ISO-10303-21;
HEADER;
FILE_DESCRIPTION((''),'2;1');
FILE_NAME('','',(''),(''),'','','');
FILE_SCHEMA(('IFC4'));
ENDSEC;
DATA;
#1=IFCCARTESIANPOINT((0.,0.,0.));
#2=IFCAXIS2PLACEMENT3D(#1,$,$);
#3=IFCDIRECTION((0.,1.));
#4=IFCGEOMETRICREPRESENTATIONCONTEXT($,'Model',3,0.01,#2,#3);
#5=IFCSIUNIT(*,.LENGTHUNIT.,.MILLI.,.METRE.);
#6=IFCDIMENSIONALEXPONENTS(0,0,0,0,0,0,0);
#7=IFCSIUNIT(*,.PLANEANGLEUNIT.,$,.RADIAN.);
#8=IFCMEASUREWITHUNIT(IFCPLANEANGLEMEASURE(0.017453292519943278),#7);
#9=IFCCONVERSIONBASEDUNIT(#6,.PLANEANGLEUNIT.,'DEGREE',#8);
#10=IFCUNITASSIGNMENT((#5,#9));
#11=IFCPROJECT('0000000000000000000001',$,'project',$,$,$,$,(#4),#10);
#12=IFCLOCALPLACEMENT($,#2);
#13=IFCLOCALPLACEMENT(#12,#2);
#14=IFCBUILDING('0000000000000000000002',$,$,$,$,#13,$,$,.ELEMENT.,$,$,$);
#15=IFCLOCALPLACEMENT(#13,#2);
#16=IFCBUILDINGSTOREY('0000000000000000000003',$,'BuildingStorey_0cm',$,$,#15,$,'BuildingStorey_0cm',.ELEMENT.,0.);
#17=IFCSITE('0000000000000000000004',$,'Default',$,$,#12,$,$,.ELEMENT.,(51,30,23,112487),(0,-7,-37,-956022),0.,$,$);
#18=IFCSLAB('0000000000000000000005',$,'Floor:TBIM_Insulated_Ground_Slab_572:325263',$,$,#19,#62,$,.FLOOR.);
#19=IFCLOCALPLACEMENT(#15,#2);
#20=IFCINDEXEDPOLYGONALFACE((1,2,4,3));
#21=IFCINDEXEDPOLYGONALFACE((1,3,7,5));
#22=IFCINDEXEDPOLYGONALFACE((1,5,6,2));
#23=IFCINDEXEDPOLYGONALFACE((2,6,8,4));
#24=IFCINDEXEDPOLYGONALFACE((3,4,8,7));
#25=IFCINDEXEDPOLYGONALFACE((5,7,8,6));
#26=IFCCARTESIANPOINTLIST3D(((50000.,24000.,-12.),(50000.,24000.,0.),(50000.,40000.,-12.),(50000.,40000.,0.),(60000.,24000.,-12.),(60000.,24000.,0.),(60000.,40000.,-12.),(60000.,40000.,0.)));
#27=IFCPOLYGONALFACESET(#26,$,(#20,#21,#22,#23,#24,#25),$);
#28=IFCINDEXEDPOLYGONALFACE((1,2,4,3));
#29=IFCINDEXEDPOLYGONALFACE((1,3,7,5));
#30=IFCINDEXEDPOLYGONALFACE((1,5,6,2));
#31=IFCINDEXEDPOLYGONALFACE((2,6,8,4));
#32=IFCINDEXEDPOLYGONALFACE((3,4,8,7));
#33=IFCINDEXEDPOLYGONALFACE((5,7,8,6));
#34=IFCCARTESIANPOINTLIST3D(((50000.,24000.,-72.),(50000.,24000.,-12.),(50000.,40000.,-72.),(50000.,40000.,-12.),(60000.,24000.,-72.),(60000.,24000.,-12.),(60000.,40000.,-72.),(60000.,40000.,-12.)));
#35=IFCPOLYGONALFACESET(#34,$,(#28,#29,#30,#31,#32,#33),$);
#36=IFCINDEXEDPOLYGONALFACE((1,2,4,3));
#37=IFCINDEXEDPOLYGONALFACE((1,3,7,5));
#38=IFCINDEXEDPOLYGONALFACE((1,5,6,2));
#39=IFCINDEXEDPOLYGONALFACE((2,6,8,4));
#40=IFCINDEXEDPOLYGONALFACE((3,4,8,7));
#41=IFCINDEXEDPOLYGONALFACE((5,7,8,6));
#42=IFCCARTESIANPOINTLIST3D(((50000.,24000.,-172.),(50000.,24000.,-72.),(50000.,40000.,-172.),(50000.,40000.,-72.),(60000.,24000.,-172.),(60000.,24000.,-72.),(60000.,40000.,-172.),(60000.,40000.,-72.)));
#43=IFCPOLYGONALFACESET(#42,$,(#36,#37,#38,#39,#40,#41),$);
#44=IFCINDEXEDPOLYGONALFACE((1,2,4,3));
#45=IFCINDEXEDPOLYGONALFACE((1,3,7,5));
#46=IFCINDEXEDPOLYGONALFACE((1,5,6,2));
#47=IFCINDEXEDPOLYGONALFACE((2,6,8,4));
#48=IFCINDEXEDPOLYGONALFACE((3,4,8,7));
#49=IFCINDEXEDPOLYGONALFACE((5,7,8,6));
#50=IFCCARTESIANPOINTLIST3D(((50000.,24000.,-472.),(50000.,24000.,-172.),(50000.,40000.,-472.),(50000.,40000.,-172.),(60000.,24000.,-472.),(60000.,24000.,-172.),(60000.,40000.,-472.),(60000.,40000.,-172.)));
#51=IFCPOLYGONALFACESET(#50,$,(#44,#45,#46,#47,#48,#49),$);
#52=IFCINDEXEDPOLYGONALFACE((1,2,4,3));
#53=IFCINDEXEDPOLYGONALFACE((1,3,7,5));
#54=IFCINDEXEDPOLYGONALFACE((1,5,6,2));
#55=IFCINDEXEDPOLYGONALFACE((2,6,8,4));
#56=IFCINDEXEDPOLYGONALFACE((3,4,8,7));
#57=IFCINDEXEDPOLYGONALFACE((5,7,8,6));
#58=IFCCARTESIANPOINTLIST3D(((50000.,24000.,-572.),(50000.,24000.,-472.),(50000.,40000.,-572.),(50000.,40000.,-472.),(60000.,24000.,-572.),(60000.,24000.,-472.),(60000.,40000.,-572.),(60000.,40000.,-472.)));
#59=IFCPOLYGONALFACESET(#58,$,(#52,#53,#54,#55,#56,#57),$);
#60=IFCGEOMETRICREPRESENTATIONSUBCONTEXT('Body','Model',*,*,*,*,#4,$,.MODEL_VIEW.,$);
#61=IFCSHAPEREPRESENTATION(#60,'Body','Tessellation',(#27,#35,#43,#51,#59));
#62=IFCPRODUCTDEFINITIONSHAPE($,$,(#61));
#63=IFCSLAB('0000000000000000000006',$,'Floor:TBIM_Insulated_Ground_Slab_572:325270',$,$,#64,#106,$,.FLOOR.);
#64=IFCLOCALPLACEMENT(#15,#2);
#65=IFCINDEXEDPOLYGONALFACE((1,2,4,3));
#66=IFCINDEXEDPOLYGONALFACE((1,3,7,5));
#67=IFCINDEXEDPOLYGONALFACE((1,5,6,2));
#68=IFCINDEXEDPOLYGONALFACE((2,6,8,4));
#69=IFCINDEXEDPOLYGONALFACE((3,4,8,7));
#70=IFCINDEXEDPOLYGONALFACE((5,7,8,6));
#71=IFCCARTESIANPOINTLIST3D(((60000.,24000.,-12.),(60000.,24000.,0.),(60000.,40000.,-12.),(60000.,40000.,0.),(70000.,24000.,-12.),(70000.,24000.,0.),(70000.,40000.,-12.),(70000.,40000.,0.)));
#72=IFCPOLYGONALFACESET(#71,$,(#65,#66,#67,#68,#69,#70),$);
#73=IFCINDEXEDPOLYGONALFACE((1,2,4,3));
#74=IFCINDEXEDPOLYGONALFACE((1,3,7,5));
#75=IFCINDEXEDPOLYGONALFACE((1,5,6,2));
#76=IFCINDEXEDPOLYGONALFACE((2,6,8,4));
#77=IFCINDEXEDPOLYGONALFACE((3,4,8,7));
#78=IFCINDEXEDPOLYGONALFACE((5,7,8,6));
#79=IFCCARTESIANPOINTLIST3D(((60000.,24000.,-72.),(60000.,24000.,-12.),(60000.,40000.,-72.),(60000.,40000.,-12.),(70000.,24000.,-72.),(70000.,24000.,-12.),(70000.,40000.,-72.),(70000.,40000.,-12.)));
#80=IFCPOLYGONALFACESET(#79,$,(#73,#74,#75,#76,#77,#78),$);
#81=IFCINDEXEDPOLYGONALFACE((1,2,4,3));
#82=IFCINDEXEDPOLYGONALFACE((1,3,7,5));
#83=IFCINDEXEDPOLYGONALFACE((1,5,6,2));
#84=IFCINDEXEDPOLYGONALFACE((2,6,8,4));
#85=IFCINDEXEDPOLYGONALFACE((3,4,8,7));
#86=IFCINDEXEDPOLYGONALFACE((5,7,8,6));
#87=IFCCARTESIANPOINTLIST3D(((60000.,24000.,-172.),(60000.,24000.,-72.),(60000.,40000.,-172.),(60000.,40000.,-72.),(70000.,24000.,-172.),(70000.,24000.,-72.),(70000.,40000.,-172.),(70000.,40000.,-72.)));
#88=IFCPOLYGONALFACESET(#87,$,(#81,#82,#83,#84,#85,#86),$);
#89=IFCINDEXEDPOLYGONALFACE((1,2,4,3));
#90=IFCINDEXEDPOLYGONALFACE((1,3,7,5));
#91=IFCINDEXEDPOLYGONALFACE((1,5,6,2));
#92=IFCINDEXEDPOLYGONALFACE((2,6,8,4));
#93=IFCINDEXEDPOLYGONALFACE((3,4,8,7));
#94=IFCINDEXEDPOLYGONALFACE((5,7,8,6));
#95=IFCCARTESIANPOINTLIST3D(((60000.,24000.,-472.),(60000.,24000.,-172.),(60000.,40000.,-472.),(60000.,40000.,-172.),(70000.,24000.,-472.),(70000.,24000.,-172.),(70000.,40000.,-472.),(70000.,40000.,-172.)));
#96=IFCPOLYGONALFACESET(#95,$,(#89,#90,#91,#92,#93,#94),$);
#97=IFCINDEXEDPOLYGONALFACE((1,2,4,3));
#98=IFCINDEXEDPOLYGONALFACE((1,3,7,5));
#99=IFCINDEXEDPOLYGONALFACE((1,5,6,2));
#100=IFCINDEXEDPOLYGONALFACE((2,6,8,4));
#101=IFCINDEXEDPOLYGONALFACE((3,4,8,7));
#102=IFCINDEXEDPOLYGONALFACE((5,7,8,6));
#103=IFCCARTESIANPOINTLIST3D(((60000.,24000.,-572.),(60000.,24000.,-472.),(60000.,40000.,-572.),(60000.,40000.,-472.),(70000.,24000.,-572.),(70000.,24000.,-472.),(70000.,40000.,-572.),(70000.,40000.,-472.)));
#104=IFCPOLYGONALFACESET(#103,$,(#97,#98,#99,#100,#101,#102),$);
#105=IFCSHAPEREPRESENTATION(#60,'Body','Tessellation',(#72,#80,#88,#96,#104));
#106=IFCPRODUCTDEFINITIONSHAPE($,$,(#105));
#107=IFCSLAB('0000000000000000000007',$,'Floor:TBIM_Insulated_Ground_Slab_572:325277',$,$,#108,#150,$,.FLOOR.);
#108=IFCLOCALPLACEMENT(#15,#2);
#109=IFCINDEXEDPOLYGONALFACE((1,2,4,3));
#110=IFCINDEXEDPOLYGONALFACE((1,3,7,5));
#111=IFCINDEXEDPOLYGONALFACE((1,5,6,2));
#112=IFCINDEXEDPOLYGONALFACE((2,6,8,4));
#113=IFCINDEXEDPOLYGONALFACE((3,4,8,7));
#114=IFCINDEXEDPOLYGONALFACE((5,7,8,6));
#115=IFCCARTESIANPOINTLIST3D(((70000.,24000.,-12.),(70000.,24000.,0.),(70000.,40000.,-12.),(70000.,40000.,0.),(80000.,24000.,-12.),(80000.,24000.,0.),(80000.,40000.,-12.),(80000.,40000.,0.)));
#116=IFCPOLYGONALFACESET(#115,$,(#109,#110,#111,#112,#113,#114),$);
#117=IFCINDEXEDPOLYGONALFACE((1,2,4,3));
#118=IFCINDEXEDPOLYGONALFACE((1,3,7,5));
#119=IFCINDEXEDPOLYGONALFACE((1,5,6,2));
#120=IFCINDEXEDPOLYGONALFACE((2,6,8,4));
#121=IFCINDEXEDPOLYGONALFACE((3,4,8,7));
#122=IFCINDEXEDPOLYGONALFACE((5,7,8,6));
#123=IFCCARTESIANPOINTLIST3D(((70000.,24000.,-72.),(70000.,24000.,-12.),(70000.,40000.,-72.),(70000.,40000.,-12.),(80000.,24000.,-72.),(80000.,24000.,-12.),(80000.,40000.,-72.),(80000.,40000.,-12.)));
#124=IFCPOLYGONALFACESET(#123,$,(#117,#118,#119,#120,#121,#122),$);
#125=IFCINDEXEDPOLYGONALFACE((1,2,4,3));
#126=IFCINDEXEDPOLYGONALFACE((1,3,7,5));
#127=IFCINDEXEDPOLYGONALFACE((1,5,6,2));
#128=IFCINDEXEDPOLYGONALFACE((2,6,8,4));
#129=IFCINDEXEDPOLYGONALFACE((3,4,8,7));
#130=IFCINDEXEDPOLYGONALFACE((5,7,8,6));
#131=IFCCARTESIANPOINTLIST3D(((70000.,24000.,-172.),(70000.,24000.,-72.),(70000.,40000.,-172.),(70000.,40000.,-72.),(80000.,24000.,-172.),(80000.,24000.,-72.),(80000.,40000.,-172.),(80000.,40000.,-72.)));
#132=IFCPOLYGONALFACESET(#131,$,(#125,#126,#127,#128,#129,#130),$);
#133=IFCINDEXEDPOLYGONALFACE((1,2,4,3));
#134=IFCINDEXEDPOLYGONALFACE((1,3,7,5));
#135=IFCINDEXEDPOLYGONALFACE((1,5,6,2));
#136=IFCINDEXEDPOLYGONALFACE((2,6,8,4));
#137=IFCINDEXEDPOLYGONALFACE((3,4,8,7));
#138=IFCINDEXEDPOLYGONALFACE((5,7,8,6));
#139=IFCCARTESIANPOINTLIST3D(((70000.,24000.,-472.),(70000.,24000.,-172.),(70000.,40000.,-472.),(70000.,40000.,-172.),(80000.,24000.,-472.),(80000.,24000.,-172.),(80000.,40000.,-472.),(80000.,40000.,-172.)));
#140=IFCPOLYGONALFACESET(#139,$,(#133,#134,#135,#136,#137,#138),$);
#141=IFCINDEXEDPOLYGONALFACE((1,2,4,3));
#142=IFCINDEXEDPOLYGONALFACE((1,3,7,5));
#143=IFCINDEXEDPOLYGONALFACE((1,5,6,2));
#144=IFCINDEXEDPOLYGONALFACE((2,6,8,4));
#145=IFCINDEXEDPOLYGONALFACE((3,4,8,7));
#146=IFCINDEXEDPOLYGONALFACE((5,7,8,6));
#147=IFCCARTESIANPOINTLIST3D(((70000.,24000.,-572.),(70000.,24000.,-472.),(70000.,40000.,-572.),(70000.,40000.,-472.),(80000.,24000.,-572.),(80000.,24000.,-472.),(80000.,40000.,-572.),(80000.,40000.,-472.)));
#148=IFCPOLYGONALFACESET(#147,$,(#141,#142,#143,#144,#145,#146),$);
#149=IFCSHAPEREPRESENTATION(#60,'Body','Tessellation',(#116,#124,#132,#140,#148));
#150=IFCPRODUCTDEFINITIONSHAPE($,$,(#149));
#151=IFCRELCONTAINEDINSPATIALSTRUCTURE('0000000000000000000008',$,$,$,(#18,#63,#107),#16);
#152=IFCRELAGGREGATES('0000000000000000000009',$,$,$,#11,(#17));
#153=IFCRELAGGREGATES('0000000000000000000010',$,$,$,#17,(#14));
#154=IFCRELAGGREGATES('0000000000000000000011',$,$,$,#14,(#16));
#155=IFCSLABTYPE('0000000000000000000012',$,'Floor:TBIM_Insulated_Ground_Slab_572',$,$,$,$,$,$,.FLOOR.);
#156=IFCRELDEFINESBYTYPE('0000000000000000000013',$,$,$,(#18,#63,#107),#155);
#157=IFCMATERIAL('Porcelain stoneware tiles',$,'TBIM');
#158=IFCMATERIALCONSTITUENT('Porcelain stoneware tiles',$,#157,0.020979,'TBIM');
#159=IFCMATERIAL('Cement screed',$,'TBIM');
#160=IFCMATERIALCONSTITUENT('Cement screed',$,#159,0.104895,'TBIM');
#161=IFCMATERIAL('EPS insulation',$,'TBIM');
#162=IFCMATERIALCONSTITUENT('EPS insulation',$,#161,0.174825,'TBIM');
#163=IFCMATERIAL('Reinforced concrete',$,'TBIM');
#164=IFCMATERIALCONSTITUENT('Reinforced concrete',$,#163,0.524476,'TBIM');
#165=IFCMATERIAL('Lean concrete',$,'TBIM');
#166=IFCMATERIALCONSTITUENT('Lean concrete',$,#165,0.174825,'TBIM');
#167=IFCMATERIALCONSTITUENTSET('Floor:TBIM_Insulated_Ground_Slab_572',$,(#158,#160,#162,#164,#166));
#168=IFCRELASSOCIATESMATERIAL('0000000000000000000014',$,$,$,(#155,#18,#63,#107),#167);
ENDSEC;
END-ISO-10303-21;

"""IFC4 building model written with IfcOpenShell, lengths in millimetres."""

from ifc_helpers import new_model, entity, si_unit, converted_unit, direction, frame, origin, place, context, subcontext, project, spatial, indexed_curve, outline, extrude, material, constituent, constituent_set, type_object, element, save


model = new_model("IFC4")

# Units and contexts
model_context = context("Model", 3, precision=0.01, world=origin(), true_north=direction((0.0, 1.0)))
body_context = subcontext(model_context, "Body", "Model", "MODEL_VIEW")
ifc_project = project(units=[si_unit("LENGTHUNIT", "METRE", prefix="MILLI"), converted_unit("PLANEANGLEUNIT", "DEGREE", entity("IfcPlaneAngleMeasure", 0.017453292519943278), si_unit("PLANEANGLEUNIT", "RADIAN"), dimensions=[0, 0, 0, 0, 0, 0, 0])], contexts=[model_context])

# Site, building, storey
site_placement = place(None, origin())
site = spatial("IfcSite", under=ifc_project, at=site_placement, Name="Default", CompositionType="ELEMENT", RefLatitude=(51, 30, 23, 112487), RefLongitude=(0, -7, -37, -956022), RefElevation=0.0)
building_placement = place(site_placement, origin())
building = spatial("IfcBuilding", under=site, at=building_placement, CompositionType="ELEMENT")
storey_placement = place(building_placement, origin())
storey = spatial("IfcBuildingStorey", under=building, at=storey_placement, Name="BuildingStorey_0cm", LongName="BuildingStorey_0cm", CompositionType="ELEMENT", Elevation=0.0)

# Slabs
ifc_material_1 = material(Name="Porcelain stoneware tiles", Category="TBIM")
ifc_constituent_1 = constituent(ifc_material_1, Name="Porcelain stoneware tiles", Category="TBIM", fraction=0.020979)
ifc_material_2 = material(Name="Cement screed", Category="TBIM")
ifc_constituent_2 = constituent(ifc_material_2, Name="Cement screed", Category="TBIM", fraction=0.104895)
ifc_material_3 = material(Name="EPS insulation", Category="TBIM")
ifc_constituent_3 = constituent(ifc_material_3, Name="EPS insulation", Category="TBIM", fraction=0.174825)
ifc_material_4 = material(Name="Reinforced concrete", Category="TBIM")
ifc_constituent_4 = constituent(ifc_material_4, Name="Reinforced concrete", Category="TBIM", fraction=0.524476)
ifc_material_5 = material(Name="Lean concrete", Category="TBIM")
ifc_constituent_5 = constituent(ifc_material_5, Name="Lean concrete", Category="TBIM", fraction=0.174825)
ifc_constituent_set_1 = constituent_set(constituents=[ifc_constituent_1, ifc_constituent_2, ifc_constituent_3, ifc_constituent_4, ifc_constituent_5], Name="Floor:TBIM_Insulated_Ground_Slab_572")
slab_type = type_object("IfcSlabType", Name="Floor:TBIM_Insulated_Ground_Slab_572", PredefinedType="FLOOR", material=ifc_constituent_set_1)
slab_1_placement = place(storey_placement, origin())
element("IfcSlab", 1, at=slab_1_placement, inside=storey, type_object=slab_type, material=ifc_constituent_set_1, Name="Floor:TBIM_Insulated_Ground_Slab_572:325263", PredefinedType="FLOOR", context=body_context, shape_type="SweptSolid", body=[
    extrude(outline(indexed_curve([(-5000.0, -8000.0), (5000.0, -8000.0), (5000.0, 8000.0), (-5000.0, 8000.0), (-5000.0, -8000.0)], self_intersect=False)), frame((55000.0, 32000.0, -12.0), z_axis=(0.0, 0.0, 1.0), x_axis=(-1.0, 0.0, 0.0)), (0.0, 0.0, 1.0), 12.0),
    extrude(outline(indexed_curve([(-5000.0, -8000.0), (5000.0, -8000.0), (5000.0, 8000.0), (-5000.0, 8000.0), (-5000.0, -8000.0)], self_intersect=False)), frame((55000.0, 32000.0, -72.0), z_axis=(0.0, 0.0, 1.0), x_axis=(-1.0, 0.0, 0.0)), (0.0, 0.0, 1.0), 60.0),
    extrude(outline(indexed_curve([(-5000.0, -8000.0), (5000.0, -8000.0), (5000.0, 8000.0), (-5000.0, 8000.0), (-5000.0, -8000.0)], self_intersect=False)), frame((55000.0, 32000.0, -172.0), z_axis=(0.0, 0.0, 1.0), x_axis=(-1.0, 0.0, 0.0)), (0.0, 0.0, 1.0), 100.0),
    extrude(outline(indexed_curve([(-5000.0, -8000.0), (5000.0, -8000.0), (5000.0, 8000.0), (-5000.0, 8000.0), (-5000.0, -8000.0)], self_intersect=False)), frame((55000.0, 32000.0, -472.0), z_axis=(0.0, 0.0, 1.0), x_axis=(-1.0, 0.0, 0.0)), (0.0, 0.0, 1.0), 300.0),
    extrude(outline(indexed_curve([(-5000.0, -8000.0), (5000.0, -8000.0), (5000.0, 8000.0), (-5000.0, 8000.0), (-5000.0, -8000.0)], self_intersect=False)), frame((55000.0, 32000.0, -572.0), z_axis=(0.0, 0.0, 1.0), x_axis=(-1.0, 0.0, 0.0)), (0.0, 0.0, 1.0), 100.0),
])
slab_2_placement = place(storey_placement, origin())
element("IfcSlab", 2, at=slab_2_placement, inside=storey, type_object=slab_type, material=ifc_constituent_set_1, Name="Floor:TBIM_Insulated_Ground_Slab_572:325270", PredefinedType="FLOOR", context=body_context, shape_type="SweptSolid", body=[
    extrude(outline(indexed_curve([(-5000.0, -8000.0), (5000.0, -8000.0), (5000.0, 8000.0), (-5000.0, 8000.0), (-5000.0, -8000.0)], self_intersect=False)), frame((65000.0, 32000.0, -12.0), z_axis=(0.0, 0.0, 1.0), x_axis=(-1.0, 0.0, 0.0)), (0.0, 0.0, 1.0), 12.0),
    extrude(outline(indexed_curve([(-5000.0, -8000.0), (5000.0, -8000.0), (5000.0, 8000.0), (-5000.0, 8000.0), (-5000.0, -8000.0)], self_intersect=False)), frame((65000.0, 32000.0, -72.0), z_axis=(0.0, 0.0, 1.0), x_axis=(-1.0, 0.0, 0.0)), (0.0, 0.0, 1.0), 60.0),
    extrude(outline(indexed_curve([(-5000.0, -8000.0), (5000.0, -8000.0), (5000.0, 8000.0), (-5000.0, 8000.0), (-5000.0, -8000.0)], self_intersect=False)), frame((65000.0, 32000.0, -172.0), z_axis=(0.0, 0.0, 1.0), x_axis=(-1.0, 0.0, 0.0)), (0.0, 0.0, 1.0), 100.0),
    extrude(outline(indexed_curve([(-5000.0, -8000.0), (5000.0, -8000.0), (5000.0, 8000.0), (-5000.0, 8000.0), (-5000.0, -8000.0)], self_intersect=False)), frame((65000.0, 32000.0, -472.0), z_axis=(0.0, 0.0, 1.0), x_axis=(-1.0, 0.0, 0.0)), (0.0, 0.0, 1.0), 300.0),
    extrude(outline(indexed_curve([(-5000.0, -8000.0), (5000.0, -8000.0), (5000.0, 8000.0), (-5000.0, 8000.0), (-5000.0, -8000.0)], self_intersect=False)), frame((65000.0, 32000.0, -572.0), z_axis=(0.0, 0.0, 1.0), x_axis=(-1.0, 0.0, 0.0)), (0.0, 0.0, 1.0), 100.0),
])
slab_3_placement = place(storey_placement, origin())
element("IfcSlab", 3, at=slab_3_placement, inside=storey, type_object=slab_type, material=ifc_constituent_set_1, Name="Floor:TBIM_Insulated_Ground_Slab_572:325277", PredefinedType="FLOOR", context=body_context, shape_type="SweptSolid", body=[
    extrude(outline(indexed_curve([(-5000.0, -8000.0), (5000.0, -8000.0), (5000.0, 8000.0), (-5000.0, 8000.0), (-5000.0, -8000.0)], self_intersect=False)), frame((75000.0, 32000.0, -12.0), z_axis=(0.0, 0.0, 1.0), x_axis=(-1.0, 0.0, 0.0)), (0.0, 0.0, 1.0), 12.0),
    extrude(outline(indexed_curve([(-5000.0, -8000.0), (5000.0, -8000.0), (5000.0, 8000.0), (-5000.0, 8000.0), (-5000.0, -8000.0)], self_intersect=False)), frame((75000.0, 32000.0, -72.0), z_axis=(0.0, 0.0, 1.0), x_axis=(-1.0, 0.0, 0.0)), (0.0, 0.0, 1.0), 60.0),
    extrude(outline(indexed_curve([(-5000.0, -8000.0), (5000.0, -8000.0), (5000.0, 8000.0), (-5000.0, 8000.0), (-5000.0, -8000.0)], self_intersect=False)), frame((75000.0, 32000.0, -172.0), z_axis=(0.0, 0.0, 1.0), x_axis=(-1.0, 0.0, 0.0)), (0.0, 0.0, 1.0), 100.0),
    extrude(outline(indexed_curve([(-5000.0, -8000.0), (5000.0, -8000.0), (5000.0, 8000.0), (-5000.0, 8000.0), (-5000.0, -8000.0)], self_intersect=False)), frame((75000.0, 32000.0, -472.0), z_axis=(0.0, 0.0, 1.0), x_axis=(-1.0, 0.0, 0.0)), (0.0, 0.0, 1.0), 300.0),
    extrude(outline(indexed_curve([(-5000.0, -8000.0), (5000.0, -8000.0), (5000.0, 8000.0), (-5000.0, 8000.0), (-5000.0, -8000.0)], self_intersect=False)), frame((75000.0, 32000.0, -572.0), z_axis=(0.0, 0.0, 1.0), x_axis=(-1.0, 0.0, 0.0)), (0.0, 0.0, 1.0), 100.0),
])

save(model, "model.ifc")
